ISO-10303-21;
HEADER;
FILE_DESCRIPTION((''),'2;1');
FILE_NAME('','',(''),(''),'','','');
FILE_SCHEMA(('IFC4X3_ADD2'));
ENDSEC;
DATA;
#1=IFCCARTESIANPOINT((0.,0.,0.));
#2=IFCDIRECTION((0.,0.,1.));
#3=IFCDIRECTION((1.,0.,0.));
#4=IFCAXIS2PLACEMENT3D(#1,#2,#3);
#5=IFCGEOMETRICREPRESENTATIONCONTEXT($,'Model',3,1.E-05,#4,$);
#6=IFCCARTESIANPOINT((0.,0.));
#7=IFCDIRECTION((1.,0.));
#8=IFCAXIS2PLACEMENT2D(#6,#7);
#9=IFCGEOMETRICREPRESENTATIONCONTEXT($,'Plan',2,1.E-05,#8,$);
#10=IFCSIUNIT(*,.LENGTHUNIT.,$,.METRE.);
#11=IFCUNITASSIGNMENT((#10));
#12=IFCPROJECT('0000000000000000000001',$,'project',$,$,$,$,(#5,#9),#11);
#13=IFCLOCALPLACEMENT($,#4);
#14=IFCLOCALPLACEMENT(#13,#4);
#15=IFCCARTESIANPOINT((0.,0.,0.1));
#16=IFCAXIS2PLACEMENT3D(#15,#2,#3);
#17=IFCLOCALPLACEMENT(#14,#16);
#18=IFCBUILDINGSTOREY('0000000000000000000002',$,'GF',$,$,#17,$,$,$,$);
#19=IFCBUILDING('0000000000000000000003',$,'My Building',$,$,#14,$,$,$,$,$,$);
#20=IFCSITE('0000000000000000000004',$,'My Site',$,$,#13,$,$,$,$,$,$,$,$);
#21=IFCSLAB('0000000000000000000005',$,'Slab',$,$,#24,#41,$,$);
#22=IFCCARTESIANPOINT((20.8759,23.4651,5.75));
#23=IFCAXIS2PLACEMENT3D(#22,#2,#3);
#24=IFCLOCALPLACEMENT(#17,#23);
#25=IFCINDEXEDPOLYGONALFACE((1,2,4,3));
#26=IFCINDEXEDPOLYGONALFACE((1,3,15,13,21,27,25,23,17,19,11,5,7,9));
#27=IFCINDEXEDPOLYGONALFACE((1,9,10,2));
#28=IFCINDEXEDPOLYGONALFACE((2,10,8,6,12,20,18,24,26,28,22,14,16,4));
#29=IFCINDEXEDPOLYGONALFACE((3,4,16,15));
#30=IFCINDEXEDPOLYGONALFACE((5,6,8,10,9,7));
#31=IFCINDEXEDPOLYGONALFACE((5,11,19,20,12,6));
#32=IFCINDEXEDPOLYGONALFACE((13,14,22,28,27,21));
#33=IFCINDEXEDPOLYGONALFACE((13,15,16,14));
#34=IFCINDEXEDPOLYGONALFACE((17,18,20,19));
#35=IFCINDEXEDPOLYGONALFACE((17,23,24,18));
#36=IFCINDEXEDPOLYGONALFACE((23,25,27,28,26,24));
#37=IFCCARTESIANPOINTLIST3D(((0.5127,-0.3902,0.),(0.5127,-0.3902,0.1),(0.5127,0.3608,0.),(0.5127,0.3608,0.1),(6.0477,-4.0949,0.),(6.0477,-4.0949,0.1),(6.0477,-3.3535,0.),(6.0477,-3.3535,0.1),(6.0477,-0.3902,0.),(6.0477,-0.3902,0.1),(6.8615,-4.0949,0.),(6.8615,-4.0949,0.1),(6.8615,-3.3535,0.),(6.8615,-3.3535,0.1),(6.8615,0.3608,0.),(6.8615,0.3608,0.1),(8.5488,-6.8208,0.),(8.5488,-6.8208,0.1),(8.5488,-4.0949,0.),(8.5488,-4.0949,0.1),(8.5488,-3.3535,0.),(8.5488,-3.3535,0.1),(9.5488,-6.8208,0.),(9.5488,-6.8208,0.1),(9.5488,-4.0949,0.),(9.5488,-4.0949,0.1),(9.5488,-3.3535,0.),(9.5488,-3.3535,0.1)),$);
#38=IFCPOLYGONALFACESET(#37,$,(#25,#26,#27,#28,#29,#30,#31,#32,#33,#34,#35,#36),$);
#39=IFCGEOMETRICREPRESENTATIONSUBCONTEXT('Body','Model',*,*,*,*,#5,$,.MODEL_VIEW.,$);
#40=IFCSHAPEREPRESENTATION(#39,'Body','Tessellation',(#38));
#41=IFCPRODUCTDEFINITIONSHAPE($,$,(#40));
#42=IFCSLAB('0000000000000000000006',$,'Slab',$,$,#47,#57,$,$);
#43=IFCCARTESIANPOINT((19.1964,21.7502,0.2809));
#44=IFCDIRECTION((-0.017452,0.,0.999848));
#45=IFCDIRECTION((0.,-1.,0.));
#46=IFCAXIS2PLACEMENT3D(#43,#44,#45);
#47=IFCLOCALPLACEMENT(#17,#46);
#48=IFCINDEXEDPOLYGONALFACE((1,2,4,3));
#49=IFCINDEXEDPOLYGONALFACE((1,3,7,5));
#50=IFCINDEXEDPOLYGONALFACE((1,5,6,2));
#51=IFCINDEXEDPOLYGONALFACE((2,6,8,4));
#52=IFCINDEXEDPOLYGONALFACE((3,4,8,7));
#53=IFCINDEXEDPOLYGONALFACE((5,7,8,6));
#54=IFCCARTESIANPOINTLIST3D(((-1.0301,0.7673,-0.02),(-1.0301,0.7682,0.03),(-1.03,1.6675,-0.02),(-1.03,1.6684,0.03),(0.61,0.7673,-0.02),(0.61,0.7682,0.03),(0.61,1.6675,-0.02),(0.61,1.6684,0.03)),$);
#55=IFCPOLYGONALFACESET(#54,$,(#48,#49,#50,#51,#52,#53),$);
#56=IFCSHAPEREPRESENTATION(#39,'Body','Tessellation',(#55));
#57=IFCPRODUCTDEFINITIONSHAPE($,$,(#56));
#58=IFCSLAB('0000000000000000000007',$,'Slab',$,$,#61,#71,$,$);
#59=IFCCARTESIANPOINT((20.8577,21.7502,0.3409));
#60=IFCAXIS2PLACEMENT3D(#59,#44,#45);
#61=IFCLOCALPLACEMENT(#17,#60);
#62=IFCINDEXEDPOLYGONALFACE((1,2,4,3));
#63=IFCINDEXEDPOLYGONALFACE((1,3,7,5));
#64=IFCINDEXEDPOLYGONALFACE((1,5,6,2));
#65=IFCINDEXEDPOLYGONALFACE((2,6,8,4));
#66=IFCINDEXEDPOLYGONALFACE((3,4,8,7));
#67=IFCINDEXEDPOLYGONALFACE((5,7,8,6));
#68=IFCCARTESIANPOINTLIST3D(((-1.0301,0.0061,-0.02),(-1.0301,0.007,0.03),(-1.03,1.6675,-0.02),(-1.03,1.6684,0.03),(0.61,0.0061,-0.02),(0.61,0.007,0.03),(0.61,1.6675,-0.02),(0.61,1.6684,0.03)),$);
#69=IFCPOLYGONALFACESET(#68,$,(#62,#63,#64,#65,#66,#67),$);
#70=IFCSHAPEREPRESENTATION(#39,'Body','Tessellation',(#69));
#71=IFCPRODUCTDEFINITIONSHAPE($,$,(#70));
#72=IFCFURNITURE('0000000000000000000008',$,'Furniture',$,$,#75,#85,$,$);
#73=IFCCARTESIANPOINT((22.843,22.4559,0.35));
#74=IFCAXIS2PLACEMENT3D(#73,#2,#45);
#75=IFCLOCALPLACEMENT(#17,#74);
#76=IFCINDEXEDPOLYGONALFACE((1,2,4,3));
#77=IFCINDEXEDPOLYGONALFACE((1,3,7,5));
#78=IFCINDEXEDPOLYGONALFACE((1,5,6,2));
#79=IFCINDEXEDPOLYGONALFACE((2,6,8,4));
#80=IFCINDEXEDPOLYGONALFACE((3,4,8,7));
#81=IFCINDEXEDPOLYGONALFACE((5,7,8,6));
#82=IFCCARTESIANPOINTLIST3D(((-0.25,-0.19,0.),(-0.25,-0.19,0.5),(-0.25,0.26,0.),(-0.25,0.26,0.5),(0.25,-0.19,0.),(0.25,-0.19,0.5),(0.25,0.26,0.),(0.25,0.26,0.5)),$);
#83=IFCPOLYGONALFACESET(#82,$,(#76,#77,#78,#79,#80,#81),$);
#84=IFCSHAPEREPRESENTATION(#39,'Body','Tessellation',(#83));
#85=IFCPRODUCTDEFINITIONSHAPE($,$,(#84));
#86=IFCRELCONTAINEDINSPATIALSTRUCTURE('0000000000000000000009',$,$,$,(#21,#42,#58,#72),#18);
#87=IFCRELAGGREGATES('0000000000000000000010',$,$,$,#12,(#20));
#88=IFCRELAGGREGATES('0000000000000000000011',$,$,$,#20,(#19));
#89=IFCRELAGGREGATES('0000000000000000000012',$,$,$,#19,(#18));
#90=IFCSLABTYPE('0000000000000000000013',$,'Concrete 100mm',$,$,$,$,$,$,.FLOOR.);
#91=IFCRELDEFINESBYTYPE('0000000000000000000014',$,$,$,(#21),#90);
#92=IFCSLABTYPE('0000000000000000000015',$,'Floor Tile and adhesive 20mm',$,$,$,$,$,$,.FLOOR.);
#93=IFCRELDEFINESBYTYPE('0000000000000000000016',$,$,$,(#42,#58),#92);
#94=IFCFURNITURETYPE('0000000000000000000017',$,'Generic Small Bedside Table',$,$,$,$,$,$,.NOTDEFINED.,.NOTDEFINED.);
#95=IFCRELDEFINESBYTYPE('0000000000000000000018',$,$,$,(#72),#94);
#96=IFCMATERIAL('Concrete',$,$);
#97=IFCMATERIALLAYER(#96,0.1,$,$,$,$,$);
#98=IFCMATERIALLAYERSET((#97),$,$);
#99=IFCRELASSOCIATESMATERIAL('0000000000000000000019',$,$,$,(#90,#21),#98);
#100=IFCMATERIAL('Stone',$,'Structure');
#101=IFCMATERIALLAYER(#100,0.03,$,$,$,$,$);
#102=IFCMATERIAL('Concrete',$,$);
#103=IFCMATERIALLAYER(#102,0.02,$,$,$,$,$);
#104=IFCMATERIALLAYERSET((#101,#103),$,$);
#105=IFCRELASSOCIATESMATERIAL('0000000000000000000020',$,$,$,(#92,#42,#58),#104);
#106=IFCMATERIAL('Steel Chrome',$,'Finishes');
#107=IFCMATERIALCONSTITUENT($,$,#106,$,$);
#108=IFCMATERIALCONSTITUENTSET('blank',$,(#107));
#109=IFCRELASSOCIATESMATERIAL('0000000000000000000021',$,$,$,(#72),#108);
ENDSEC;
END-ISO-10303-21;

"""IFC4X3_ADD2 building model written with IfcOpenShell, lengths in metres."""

from ifc_helpers import new_model, entity, si_unit, frame, origin_with_axes, origin_2d_with_axis, place, context, subcontext, project, spatial, line, indexed_curve, outline, extrude, shape, source, transform, mapped, material, layer, layer_set, layer_usage, constituent, constituent_set, type_object, type_shapes, element, save


model = new_model("IFC4X3_ADD2")

# Units and contexts
model_context = context("Model", 3, precision=1e-05, world=origin_with_axes())
plan_context = context("Plan", 2, precision=1e-05, world=origin_2d_with_axis())
body_context_1 = subcontext(model_context, "Body", "Model", "MODEL_VIEW")
body_context_2 = subcontext(plan_context, "Body", "Plan", "PLAN_VIEW")
ifc_project = project(units=[si_unit("LENGTHUNIT", "METRE")], contexts=[model_context, plan_context])

# Site, building, storey
site_placement = place(None, origin_with_axes())
site = spatial("IfcSite", under=ifc_project, at=site_placement, Name="My Site")
building_placement = place(site_placement, origin_with_axes())
building = spatial("IfcBuilding", under=site, at=building_placement, Name="My Building")
storey_placement = place(building_placement, frame((0.0, 0.0, 0.1), z_axis=(0.0, 0.0, 1.0), x_axis=(1.0, 0.0, 0.0)))
storey = spatial("IfcBuildingStorey", under=building, at=storey_placement, Name="GF")

# Slabs
ifc_material_1 = material(Name="Concrete")
ifc_layer_1 = layer(ifc_material_1, 0.1)
ifc_layer_set_1 = layer_set([ifc_layer_1])
ifc_layer_usage_1 = layer_usage(ifc_layer_set_1, "AXIS3", "POSITIVE", 0.0)
slab_type_1 = type_object("IfcSlabType", Name="Concrete 100mm", PredefinedType="FLOOR", material=ifc_layer_set_1)
slab_1_placement = place(storey_placement, frame((20.8759, 23.4651, 5.75), z_axis=(0.0, 0.0, 1.0), x_axis=(1.0, 0.0, 0.0)))
element("IfcSlab", 1, at=slab_1_placement, inside=storey, type_object=slab_type_1, material=ifc_layer_usage_1, Name="Slab", context=body_context_1, shape_type="SweptSolid", body=[
    extrude(outline(indexed_curve([(9.5488, -4.0949), (9.5488, -3.3535), (8.5488, -3.3535), (6.8615, -3.3535), (6.8615, 0.3608), (0.5127, 0.3608), (0.5127, -0.3902), (6.0477, -0.3902), (6.0477, -3.3535), (6.0477, -4.0949), (6.8615, -4.0949), (8.5488, -4.0949), (8.5488, -6.8208), (9.5488, -6.8208)], segments=[line(11, 12), line(12, 13), line(13, 14), line(14, 1), line(1, 2), line(2, 3), line(3, 4), line(4, 5), line(5, 6), line(6, 7), line(7, 8), line(8, 9), line(9, 10), line(10, 11)], self_intersect=False)), None, (0.0, 0.0, 1.0), 0.1),
])
ifc_material_2 = material(Name="Stone", Category="Structure")
ifc_layer_2 = layer(ifc_material_2, 0.03)
ifc_material_3 = material(Name="Concrete")
ifc_layer_3 = layer(ifc_material_3, 0.02)
ifc_layer_set_2 = layer_set([ifc_layer_2, ifc_layer_3])
ifc_layer_usage_2 = layer_usage(ifc_layer_set_2, "AXIS3", "POSITIVE", -0.02)
slab_type_2 = type_object("IfcSlabType", Name="Floor Tile and adhesive 20mm", PredefinedType="FLOOR", material=ifc_layer_set_2)
slab_2_placement = place(storey_placement, frame((19.1964, 21.7502, 0.2809), z_axis=(-0.017452, 0.0, 0.999848), x_axis=(0.0, -1.0, 0.0)))
element("IfcSlab", 2, at=slab_2_placement, inside=storey, type_object=slab_type_2, material=ifc_layer_usage_2, Name="Slab", context=body_context_1, shape_type="SweptSolid", body=[
    extrude(outline(indexed_curve([(-1.0301, 0.7677), (0.61, 0.7677), (0.61, 1.6678), (-1.03, 1.6678), (-1.0301, 0.7677)])), frame((0.0, -0.0003, -0.02), z_axis=(0.0, 0.0, 1.0), x_axis=(1.0, 0.0, 0.0)), (0.0, 0.017452, 0.999848), 0.05),
])
ifc_layer_usage_3 = layer_usage(ifc_layer_set_2, "AXIS3", "POSITIVE", -0.02)
slab_3_placement = place(storey_placement, frame((20.8577, 21.7502, 0.3409), z_axis=(-0.017452, 0.0, 0.999848), x_axis=(0.0, -1.0, 0.0)))
element("IfcSlab", 3, at=slab_3_placement, inside=storey, type_object=slab_type_2, material=ifc_layer_usage_3, Name="Slab", context=body_context_1, shape_type="SweptSolid", body=[
    extrude(outline(indexed_curve([(-1.03, 1.6678), (0.61, 1.6678), (0.61, 0.0065), (-1.0301, 0.0065), (-1.03, 1.6678)])), frame((0.0, -0.0003, -0.02), z_axis=(0.0, 0.0, 1.0), x_axis=(1.0, 0.0, 0.0)), (0.0, 0.017452, 0.999848), 0.05),
])

# Furniture
ifc_material_4 = material(Name="Steel Chrome", Category="Finishes")
ifc_constituent_1 = constituent(ifc_material_4)
ifc_constituent_set_1 = constituent_set(constituents=[ifc_constituent_1], Name="blank")
furniture_type = type_object("IfcFurnitureType", Name="Generic Small Bedside Table", AssemblyPlace="NOTDEFINED", PredefinedType="NOTDEFINED")
shared_shape_1 = source(origin_with_axes(), body_context_1, "Body", "SweptSolid", [
    extrude(outline(indexed_curve([(0.5, 0.45), (0.5, 0.0), (0.0, 0.0), (0.0, 0.45)], segments=[line(4, 1), line(1, 2), line(2, 3), line(3, 4)], self_intersect=False)), frame((-0.25, -0.19, 0.0), z_axis=(0.0, 0.0, 1.0), x_axis=(1.0, 0.0, 0.0)), (0.0, 0.0, 1.0), 0.5),
])
shared_shape_2 = source(origin_with_axes(), body_context_2, "Body", "Annotation2D", [
    entity("IfcGeometricCurveSet", [entity("IfcIndexedPolyCurve", entity("IfcCartesianPointList2D", [[-0.25, -0.19], [0.25, -0.19], [0.25, 0.26], [-0.25, 0.26]]), [entity("IfcLineIndex", [1, 2]), entity("IfcLineIndex", [2, 3]), entity("IfcLineIndex", [3, 4]), entity("IfcLineIndex", [4, 1])])]),
])
type_shapes(furniture_type, [shared_shape_1, shared_shape_2])
furniture_placement = place(storey_placement, frame((22.843, 22.4559, 0.35), z_axis=(0.0, 0.0, 1.0), x_axis=(0.0, -1.0, 0.0)))
element("IfcFurniture", 4, at=furniture_placement, inside=storey, type_object=furniture_type, material=ifc_constituent_set_1, Name="Furniture", shapes=[
    shape(body_context_1, "Body", "MappedRepresentation", [mapped(shared_shape_1, transform((0.0, 0.0, 0.0), x_axis=(1.0, 0.0, 0.0), y_axis=(0.0, 1.0, 0.0), z_axis=(0.0, 0.0, 1.0), scale=1.0))]),
    shape(body_context_2, "Body", "MappedRepresentation", [mapped(shared_shape_2, transform((0.0, 0.0, 0.0), x_axis=(1.0, 0.0, 0.0), y_axis=(0.0, 1.0, 0.0), z_axis=(0.0, 0.0, 1.0), scale=1.0))]),
])

save(model, "model.ifc")
